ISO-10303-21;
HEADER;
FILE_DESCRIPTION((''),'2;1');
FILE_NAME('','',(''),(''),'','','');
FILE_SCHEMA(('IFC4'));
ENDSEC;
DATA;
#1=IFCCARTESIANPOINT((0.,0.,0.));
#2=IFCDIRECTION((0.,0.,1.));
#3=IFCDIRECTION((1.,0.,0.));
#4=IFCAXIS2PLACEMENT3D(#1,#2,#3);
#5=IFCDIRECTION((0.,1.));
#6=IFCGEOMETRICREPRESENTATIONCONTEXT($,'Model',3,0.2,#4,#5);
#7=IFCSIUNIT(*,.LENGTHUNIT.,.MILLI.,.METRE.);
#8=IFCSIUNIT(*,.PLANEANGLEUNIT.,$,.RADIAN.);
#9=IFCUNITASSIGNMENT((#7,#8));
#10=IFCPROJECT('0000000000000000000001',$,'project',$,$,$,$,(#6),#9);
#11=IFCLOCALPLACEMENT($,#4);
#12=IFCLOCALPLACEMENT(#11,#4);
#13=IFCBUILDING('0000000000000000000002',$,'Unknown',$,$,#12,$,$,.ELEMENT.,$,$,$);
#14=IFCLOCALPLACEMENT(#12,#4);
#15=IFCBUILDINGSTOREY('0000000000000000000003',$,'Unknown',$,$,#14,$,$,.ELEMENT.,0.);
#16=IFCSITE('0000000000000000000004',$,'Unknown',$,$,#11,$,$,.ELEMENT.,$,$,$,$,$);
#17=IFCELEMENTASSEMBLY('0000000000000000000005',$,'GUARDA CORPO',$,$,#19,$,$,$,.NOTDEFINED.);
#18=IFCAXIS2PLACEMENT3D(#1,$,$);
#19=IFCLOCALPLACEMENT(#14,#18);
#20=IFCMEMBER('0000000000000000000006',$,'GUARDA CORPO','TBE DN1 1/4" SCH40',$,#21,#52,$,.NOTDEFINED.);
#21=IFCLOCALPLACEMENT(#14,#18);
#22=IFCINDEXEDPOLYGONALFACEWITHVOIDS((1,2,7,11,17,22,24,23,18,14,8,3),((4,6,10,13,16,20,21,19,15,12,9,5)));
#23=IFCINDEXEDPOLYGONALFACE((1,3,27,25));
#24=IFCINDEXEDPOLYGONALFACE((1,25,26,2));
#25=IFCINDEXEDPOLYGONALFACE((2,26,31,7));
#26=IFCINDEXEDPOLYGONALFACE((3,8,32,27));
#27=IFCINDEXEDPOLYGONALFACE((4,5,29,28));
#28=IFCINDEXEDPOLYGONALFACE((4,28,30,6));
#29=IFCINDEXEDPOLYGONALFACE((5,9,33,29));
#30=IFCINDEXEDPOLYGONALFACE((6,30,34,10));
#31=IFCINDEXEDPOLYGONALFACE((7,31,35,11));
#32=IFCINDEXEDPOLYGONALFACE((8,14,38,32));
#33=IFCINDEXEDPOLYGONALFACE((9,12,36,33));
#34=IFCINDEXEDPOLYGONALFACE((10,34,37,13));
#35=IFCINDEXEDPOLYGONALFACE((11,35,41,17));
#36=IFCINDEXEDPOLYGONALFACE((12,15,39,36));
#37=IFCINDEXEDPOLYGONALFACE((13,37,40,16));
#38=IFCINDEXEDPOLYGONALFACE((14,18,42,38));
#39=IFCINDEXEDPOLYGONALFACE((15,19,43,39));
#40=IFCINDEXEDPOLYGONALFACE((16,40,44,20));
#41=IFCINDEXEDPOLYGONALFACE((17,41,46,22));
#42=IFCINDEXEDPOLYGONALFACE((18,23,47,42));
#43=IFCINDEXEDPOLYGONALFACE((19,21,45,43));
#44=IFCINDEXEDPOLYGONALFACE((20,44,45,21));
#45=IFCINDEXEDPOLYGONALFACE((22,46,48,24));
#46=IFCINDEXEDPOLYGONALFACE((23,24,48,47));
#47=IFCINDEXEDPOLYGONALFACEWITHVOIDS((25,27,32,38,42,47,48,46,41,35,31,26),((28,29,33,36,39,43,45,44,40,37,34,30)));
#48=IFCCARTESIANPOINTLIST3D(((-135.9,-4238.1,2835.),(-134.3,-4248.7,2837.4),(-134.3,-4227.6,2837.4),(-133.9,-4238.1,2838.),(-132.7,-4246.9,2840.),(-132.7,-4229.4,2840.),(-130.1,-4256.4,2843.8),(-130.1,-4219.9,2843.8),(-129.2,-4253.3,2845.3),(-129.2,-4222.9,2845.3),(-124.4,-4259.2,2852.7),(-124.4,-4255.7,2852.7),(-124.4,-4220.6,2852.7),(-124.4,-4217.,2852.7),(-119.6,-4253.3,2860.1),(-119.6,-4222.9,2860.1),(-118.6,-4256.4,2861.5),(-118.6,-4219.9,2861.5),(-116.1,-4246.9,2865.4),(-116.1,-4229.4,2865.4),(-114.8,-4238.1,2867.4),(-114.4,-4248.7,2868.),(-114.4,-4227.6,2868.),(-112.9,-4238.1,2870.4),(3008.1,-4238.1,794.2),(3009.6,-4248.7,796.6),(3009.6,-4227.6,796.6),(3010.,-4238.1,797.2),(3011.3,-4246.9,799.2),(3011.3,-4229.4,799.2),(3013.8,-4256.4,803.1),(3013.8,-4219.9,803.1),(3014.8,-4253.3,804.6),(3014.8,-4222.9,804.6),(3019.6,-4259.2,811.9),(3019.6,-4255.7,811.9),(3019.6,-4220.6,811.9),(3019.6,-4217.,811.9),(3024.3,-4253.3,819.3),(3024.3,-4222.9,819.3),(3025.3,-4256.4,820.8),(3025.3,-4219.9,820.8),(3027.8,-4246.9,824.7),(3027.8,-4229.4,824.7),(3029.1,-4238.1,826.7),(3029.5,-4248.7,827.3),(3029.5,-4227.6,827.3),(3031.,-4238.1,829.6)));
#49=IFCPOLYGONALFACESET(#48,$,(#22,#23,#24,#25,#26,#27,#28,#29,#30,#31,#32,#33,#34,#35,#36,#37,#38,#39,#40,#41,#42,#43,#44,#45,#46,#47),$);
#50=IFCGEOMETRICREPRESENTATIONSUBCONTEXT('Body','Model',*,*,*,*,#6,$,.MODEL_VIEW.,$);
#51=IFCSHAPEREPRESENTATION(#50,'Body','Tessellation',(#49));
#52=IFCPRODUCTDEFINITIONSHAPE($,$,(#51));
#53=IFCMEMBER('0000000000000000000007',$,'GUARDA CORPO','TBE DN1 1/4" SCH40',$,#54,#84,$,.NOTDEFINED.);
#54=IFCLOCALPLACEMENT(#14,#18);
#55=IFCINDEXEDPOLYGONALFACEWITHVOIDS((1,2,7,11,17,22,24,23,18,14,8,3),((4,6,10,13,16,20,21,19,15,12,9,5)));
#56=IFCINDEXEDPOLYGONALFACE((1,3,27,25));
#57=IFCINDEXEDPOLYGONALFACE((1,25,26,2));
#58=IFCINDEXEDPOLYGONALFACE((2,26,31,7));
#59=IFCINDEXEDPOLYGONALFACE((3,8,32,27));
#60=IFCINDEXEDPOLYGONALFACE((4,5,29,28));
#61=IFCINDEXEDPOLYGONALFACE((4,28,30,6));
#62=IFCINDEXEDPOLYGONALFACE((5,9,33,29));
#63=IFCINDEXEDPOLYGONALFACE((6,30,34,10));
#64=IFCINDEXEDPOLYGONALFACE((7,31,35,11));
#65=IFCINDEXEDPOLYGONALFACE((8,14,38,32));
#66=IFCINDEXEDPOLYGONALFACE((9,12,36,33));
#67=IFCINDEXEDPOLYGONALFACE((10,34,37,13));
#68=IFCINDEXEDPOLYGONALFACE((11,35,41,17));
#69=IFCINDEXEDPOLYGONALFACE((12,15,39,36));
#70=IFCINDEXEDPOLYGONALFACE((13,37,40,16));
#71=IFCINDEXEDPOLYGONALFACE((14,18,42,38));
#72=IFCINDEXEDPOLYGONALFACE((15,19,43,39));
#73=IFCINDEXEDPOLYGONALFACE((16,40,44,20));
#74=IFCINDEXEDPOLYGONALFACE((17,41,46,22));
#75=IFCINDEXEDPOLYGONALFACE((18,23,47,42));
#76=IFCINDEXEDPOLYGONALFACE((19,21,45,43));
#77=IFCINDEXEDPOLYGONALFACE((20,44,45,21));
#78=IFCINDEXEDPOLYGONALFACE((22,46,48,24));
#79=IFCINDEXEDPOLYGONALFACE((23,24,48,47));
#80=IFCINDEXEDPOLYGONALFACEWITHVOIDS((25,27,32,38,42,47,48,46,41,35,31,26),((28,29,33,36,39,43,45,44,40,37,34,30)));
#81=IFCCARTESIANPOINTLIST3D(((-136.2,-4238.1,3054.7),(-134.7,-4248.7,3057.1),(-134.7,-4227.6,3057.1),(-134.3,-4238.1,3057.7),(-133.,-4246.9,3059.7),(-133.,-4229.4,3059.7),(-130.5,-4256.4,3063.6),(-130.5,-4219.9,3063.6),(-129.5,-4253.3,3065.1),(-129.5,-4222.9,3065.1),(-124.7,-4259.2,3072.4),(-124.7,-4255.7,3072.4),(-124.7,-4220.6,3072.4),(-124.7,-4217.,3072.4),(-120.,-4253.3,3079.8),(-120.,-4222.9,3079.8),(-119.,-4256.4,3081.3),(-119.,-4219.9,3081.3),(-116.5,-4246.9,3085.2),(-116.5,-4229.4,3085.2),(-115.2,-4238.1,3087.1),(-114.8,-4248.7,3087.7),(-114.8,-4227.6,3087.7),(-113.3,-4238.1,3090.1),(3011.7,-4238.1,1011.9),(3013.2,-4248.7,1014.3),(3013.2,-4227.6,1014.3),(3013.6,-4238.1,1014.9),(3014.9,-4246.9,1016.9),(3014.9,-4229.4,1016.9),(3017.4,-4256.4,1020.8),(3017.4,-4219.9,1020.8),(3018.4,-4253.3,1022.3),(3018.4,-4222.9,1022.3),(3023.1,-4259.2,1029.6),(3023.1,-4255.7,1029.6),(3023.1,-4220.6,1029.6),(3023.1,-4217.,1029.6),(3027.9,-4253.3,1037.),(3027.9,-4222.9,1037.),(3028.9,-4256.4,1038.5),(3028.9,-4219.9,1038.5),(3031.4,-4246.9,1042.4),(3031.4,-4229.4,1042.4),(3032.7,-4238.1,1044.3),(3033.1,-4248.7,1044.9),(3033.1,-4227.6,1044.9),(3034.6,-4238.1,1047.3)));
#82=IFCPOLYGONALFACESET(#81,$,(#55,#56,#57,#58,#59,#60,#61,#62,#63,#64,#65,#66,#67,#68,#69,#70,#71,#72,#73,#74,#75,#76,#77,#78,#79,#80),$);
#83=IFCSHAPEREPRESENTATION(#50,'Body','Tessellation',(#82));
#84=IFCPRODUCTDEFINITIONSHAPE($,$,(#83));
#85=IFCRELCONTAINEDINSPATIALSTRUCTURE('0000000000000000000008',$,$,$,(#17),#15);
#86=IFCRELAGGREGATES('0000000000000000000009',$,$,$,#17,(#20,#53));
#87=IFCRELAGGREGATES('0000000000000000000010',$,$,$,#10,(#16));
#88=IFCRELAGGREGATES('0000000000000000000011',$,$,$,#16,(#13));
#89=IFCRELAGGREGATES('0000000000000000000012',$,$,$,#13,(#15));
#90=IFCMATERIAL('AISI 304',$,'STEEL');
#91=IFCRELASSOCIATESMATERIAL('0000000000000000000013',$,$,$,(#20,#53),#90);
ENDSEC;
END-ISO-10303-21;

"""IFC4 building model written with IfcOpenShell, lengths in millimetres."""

from ifc_helpers import new_model, si_unit, direction, frame, origin_with_axes, place, context, subcontext, project, spatial, line, indexed_curve, outline, extrude, material, element, aggregate, save


model = new_model("IFC4")

# Units and contexts
model_context = context("Model", 3, precision=0.2, world=origin_with_axes(), true_north=direction((0.0, 1.0)))
body_context = subcontext(model_context, "Body", "Model", "MODEL_VIEW")
ifc_project = project(units=[si_unit("LENGTHUNIT", "METRE", prefix="MILLI"), si_unit("PLANEANGLEUNIT", "RADIAN")], contexts=[model_context])

# Site, building, storey
site_placement = place(None, origin_with_axes())
site = spatial("IfcSite", under=ifc_project, at=site_placement, Name="Unknown", CompositionType="ELEMENT")
building_placement = place(site_placement, origin_with_axes())
building = spatial("IfcBuilding", under=site, at=building_placement, Name="Unknown", CompositionType="ELEMENT")
storey_placement = place(building_placement, origin_with_axes())
storey = spatial("IfcBuildingStorey", under=building, at=storey_placement, Name="Unknown", CompositionType="ELEMENT", Elevation=0.0)

# Element assembly, members
ifc_material_1 = material(Name="AISI 304", Category="STEEL")
assembly_1_placement = place(storey_placement, frame((833.2, -4289.3, 1615.0), z_axis=(-0.000512, 1.0, -0.000003), x_axis=(0.000003, 0.000003, 1.0)))
assembly_1 = element("IfcElementAssembly", 1, at=assembly_1_placement, inside=storey, Name="GUARDA CORPO", PredefinedType="NOTDEFINED")
member_1_placement = place(assembly_1_placement, frame((-803.1, 2186.4, 50.0), z_axis=(0.838787, 0.544459, -0.000281), x_axis=(0.54446, -0.838787, 0.000428)))
member_1 = element("IfcMember", 2, at=member_1_placement, material=ifc_material_1, Name="GUARDA CORPO", Description="TBE DN1 1/4\" SCH40", PredefinedType="NOTDEFINED", context=body_context, shape_type="SolidModel", body=[
    extrude(outline(indexed_curve([(21.1, 0.0), (18.3, 10.6), (10.6, 18.3), (0.0, 21.1), (-10.6, 18.3), (-18.3, 10.6), (-21.1, 0.0), (-18.3, -10.6), (-10.6, -18.3), (0.0, -21.1), (10.6, -18.3), (18.3, -10.6)], segments=[line(1, 2, 3, 4, 5, 6, 7, 8, 9, 10, 11, 12, 1)]), holes=[indexed_curve([(17.5, 0.0), (15.2, -8.8), (8.8, -15.2), (0.0, -17.5), (-8.8, -15.2), (-15.2, -8.8), (-17.5, 0.0), (-15.2, 8.8), (-8.8, 15.2), (0.0, 17.5), (8.8, 15.2), (15.2, 8.8)], segments=[line(1, 2, 3, 4, 5, 6, 7, 8, 9, 10, 11, 12, 1)])]), frame((0.0, 0.0, 0.0), z_axis=(-1.0, 0.0, 0.0), x_axis=(0.0, 0.0, 1.0)), (0.0, 0.0, -1.0), 3748.2),
])
member_2_placement = place(assembly_1_placement, frame((-585.4, 2190.0, 50.0), z_axis=(0.83885, 0.544362, -0.000281), x_axis=(0.544363, -0.83885, 0.000429)))
member_2 = element("IfcMember", 3, at=member_2_placement, material=ifc_material_1, Name="GUARDA CORPO", Description="TBE DN1 1/4\" SCH40", PredefinedType="NOTDEFINED", context=body_context, shape_type="SolidModel", body=[
    extrude(outline(indexed_curve([(21.1, 0.0), (18.3, 10.6), (10.6, 18.3), (0.0, 21.1), (-10.6, 18.3), (-18.3, 10.6), (-21.1, 0.0), (-18.3, -10.6), (-10.6, -18.3), (0.0, -21.1), (10.6, -18.3), (18.3, -10.6)], segments=[line(1, 2, 3, 4, 5, 6, 7, 8, 9, 10, 11, 12, 1)]), holes=[indexed_curve([(17.5, 0.0), (15.2, -8.8), (8.8, -15.2), (0.0, -17.5), (-8.8, -15.2), (-15.2, -8.8), (-17.5, 0.0), (-15.2, 8.8), (-8.8, 15.2), (0.0, 17.5), (8.8, 15.2), (15.2, 8.8)], segments=[line(1, 2, 3, 4, 5, 6, 7, 8, 9, 10, 11, 12, 1)])]), frame((0.0, 0.0, 0.0), z_axis=(-1.0, 0.0, 0.0), x_axis=(0.0, 0.0, 1.0)), (0.0, 0.0, -1.0), 3752.6),
])
aggregate(assembly_1, [member_1, member_2])

save(model, "model.ifc")
